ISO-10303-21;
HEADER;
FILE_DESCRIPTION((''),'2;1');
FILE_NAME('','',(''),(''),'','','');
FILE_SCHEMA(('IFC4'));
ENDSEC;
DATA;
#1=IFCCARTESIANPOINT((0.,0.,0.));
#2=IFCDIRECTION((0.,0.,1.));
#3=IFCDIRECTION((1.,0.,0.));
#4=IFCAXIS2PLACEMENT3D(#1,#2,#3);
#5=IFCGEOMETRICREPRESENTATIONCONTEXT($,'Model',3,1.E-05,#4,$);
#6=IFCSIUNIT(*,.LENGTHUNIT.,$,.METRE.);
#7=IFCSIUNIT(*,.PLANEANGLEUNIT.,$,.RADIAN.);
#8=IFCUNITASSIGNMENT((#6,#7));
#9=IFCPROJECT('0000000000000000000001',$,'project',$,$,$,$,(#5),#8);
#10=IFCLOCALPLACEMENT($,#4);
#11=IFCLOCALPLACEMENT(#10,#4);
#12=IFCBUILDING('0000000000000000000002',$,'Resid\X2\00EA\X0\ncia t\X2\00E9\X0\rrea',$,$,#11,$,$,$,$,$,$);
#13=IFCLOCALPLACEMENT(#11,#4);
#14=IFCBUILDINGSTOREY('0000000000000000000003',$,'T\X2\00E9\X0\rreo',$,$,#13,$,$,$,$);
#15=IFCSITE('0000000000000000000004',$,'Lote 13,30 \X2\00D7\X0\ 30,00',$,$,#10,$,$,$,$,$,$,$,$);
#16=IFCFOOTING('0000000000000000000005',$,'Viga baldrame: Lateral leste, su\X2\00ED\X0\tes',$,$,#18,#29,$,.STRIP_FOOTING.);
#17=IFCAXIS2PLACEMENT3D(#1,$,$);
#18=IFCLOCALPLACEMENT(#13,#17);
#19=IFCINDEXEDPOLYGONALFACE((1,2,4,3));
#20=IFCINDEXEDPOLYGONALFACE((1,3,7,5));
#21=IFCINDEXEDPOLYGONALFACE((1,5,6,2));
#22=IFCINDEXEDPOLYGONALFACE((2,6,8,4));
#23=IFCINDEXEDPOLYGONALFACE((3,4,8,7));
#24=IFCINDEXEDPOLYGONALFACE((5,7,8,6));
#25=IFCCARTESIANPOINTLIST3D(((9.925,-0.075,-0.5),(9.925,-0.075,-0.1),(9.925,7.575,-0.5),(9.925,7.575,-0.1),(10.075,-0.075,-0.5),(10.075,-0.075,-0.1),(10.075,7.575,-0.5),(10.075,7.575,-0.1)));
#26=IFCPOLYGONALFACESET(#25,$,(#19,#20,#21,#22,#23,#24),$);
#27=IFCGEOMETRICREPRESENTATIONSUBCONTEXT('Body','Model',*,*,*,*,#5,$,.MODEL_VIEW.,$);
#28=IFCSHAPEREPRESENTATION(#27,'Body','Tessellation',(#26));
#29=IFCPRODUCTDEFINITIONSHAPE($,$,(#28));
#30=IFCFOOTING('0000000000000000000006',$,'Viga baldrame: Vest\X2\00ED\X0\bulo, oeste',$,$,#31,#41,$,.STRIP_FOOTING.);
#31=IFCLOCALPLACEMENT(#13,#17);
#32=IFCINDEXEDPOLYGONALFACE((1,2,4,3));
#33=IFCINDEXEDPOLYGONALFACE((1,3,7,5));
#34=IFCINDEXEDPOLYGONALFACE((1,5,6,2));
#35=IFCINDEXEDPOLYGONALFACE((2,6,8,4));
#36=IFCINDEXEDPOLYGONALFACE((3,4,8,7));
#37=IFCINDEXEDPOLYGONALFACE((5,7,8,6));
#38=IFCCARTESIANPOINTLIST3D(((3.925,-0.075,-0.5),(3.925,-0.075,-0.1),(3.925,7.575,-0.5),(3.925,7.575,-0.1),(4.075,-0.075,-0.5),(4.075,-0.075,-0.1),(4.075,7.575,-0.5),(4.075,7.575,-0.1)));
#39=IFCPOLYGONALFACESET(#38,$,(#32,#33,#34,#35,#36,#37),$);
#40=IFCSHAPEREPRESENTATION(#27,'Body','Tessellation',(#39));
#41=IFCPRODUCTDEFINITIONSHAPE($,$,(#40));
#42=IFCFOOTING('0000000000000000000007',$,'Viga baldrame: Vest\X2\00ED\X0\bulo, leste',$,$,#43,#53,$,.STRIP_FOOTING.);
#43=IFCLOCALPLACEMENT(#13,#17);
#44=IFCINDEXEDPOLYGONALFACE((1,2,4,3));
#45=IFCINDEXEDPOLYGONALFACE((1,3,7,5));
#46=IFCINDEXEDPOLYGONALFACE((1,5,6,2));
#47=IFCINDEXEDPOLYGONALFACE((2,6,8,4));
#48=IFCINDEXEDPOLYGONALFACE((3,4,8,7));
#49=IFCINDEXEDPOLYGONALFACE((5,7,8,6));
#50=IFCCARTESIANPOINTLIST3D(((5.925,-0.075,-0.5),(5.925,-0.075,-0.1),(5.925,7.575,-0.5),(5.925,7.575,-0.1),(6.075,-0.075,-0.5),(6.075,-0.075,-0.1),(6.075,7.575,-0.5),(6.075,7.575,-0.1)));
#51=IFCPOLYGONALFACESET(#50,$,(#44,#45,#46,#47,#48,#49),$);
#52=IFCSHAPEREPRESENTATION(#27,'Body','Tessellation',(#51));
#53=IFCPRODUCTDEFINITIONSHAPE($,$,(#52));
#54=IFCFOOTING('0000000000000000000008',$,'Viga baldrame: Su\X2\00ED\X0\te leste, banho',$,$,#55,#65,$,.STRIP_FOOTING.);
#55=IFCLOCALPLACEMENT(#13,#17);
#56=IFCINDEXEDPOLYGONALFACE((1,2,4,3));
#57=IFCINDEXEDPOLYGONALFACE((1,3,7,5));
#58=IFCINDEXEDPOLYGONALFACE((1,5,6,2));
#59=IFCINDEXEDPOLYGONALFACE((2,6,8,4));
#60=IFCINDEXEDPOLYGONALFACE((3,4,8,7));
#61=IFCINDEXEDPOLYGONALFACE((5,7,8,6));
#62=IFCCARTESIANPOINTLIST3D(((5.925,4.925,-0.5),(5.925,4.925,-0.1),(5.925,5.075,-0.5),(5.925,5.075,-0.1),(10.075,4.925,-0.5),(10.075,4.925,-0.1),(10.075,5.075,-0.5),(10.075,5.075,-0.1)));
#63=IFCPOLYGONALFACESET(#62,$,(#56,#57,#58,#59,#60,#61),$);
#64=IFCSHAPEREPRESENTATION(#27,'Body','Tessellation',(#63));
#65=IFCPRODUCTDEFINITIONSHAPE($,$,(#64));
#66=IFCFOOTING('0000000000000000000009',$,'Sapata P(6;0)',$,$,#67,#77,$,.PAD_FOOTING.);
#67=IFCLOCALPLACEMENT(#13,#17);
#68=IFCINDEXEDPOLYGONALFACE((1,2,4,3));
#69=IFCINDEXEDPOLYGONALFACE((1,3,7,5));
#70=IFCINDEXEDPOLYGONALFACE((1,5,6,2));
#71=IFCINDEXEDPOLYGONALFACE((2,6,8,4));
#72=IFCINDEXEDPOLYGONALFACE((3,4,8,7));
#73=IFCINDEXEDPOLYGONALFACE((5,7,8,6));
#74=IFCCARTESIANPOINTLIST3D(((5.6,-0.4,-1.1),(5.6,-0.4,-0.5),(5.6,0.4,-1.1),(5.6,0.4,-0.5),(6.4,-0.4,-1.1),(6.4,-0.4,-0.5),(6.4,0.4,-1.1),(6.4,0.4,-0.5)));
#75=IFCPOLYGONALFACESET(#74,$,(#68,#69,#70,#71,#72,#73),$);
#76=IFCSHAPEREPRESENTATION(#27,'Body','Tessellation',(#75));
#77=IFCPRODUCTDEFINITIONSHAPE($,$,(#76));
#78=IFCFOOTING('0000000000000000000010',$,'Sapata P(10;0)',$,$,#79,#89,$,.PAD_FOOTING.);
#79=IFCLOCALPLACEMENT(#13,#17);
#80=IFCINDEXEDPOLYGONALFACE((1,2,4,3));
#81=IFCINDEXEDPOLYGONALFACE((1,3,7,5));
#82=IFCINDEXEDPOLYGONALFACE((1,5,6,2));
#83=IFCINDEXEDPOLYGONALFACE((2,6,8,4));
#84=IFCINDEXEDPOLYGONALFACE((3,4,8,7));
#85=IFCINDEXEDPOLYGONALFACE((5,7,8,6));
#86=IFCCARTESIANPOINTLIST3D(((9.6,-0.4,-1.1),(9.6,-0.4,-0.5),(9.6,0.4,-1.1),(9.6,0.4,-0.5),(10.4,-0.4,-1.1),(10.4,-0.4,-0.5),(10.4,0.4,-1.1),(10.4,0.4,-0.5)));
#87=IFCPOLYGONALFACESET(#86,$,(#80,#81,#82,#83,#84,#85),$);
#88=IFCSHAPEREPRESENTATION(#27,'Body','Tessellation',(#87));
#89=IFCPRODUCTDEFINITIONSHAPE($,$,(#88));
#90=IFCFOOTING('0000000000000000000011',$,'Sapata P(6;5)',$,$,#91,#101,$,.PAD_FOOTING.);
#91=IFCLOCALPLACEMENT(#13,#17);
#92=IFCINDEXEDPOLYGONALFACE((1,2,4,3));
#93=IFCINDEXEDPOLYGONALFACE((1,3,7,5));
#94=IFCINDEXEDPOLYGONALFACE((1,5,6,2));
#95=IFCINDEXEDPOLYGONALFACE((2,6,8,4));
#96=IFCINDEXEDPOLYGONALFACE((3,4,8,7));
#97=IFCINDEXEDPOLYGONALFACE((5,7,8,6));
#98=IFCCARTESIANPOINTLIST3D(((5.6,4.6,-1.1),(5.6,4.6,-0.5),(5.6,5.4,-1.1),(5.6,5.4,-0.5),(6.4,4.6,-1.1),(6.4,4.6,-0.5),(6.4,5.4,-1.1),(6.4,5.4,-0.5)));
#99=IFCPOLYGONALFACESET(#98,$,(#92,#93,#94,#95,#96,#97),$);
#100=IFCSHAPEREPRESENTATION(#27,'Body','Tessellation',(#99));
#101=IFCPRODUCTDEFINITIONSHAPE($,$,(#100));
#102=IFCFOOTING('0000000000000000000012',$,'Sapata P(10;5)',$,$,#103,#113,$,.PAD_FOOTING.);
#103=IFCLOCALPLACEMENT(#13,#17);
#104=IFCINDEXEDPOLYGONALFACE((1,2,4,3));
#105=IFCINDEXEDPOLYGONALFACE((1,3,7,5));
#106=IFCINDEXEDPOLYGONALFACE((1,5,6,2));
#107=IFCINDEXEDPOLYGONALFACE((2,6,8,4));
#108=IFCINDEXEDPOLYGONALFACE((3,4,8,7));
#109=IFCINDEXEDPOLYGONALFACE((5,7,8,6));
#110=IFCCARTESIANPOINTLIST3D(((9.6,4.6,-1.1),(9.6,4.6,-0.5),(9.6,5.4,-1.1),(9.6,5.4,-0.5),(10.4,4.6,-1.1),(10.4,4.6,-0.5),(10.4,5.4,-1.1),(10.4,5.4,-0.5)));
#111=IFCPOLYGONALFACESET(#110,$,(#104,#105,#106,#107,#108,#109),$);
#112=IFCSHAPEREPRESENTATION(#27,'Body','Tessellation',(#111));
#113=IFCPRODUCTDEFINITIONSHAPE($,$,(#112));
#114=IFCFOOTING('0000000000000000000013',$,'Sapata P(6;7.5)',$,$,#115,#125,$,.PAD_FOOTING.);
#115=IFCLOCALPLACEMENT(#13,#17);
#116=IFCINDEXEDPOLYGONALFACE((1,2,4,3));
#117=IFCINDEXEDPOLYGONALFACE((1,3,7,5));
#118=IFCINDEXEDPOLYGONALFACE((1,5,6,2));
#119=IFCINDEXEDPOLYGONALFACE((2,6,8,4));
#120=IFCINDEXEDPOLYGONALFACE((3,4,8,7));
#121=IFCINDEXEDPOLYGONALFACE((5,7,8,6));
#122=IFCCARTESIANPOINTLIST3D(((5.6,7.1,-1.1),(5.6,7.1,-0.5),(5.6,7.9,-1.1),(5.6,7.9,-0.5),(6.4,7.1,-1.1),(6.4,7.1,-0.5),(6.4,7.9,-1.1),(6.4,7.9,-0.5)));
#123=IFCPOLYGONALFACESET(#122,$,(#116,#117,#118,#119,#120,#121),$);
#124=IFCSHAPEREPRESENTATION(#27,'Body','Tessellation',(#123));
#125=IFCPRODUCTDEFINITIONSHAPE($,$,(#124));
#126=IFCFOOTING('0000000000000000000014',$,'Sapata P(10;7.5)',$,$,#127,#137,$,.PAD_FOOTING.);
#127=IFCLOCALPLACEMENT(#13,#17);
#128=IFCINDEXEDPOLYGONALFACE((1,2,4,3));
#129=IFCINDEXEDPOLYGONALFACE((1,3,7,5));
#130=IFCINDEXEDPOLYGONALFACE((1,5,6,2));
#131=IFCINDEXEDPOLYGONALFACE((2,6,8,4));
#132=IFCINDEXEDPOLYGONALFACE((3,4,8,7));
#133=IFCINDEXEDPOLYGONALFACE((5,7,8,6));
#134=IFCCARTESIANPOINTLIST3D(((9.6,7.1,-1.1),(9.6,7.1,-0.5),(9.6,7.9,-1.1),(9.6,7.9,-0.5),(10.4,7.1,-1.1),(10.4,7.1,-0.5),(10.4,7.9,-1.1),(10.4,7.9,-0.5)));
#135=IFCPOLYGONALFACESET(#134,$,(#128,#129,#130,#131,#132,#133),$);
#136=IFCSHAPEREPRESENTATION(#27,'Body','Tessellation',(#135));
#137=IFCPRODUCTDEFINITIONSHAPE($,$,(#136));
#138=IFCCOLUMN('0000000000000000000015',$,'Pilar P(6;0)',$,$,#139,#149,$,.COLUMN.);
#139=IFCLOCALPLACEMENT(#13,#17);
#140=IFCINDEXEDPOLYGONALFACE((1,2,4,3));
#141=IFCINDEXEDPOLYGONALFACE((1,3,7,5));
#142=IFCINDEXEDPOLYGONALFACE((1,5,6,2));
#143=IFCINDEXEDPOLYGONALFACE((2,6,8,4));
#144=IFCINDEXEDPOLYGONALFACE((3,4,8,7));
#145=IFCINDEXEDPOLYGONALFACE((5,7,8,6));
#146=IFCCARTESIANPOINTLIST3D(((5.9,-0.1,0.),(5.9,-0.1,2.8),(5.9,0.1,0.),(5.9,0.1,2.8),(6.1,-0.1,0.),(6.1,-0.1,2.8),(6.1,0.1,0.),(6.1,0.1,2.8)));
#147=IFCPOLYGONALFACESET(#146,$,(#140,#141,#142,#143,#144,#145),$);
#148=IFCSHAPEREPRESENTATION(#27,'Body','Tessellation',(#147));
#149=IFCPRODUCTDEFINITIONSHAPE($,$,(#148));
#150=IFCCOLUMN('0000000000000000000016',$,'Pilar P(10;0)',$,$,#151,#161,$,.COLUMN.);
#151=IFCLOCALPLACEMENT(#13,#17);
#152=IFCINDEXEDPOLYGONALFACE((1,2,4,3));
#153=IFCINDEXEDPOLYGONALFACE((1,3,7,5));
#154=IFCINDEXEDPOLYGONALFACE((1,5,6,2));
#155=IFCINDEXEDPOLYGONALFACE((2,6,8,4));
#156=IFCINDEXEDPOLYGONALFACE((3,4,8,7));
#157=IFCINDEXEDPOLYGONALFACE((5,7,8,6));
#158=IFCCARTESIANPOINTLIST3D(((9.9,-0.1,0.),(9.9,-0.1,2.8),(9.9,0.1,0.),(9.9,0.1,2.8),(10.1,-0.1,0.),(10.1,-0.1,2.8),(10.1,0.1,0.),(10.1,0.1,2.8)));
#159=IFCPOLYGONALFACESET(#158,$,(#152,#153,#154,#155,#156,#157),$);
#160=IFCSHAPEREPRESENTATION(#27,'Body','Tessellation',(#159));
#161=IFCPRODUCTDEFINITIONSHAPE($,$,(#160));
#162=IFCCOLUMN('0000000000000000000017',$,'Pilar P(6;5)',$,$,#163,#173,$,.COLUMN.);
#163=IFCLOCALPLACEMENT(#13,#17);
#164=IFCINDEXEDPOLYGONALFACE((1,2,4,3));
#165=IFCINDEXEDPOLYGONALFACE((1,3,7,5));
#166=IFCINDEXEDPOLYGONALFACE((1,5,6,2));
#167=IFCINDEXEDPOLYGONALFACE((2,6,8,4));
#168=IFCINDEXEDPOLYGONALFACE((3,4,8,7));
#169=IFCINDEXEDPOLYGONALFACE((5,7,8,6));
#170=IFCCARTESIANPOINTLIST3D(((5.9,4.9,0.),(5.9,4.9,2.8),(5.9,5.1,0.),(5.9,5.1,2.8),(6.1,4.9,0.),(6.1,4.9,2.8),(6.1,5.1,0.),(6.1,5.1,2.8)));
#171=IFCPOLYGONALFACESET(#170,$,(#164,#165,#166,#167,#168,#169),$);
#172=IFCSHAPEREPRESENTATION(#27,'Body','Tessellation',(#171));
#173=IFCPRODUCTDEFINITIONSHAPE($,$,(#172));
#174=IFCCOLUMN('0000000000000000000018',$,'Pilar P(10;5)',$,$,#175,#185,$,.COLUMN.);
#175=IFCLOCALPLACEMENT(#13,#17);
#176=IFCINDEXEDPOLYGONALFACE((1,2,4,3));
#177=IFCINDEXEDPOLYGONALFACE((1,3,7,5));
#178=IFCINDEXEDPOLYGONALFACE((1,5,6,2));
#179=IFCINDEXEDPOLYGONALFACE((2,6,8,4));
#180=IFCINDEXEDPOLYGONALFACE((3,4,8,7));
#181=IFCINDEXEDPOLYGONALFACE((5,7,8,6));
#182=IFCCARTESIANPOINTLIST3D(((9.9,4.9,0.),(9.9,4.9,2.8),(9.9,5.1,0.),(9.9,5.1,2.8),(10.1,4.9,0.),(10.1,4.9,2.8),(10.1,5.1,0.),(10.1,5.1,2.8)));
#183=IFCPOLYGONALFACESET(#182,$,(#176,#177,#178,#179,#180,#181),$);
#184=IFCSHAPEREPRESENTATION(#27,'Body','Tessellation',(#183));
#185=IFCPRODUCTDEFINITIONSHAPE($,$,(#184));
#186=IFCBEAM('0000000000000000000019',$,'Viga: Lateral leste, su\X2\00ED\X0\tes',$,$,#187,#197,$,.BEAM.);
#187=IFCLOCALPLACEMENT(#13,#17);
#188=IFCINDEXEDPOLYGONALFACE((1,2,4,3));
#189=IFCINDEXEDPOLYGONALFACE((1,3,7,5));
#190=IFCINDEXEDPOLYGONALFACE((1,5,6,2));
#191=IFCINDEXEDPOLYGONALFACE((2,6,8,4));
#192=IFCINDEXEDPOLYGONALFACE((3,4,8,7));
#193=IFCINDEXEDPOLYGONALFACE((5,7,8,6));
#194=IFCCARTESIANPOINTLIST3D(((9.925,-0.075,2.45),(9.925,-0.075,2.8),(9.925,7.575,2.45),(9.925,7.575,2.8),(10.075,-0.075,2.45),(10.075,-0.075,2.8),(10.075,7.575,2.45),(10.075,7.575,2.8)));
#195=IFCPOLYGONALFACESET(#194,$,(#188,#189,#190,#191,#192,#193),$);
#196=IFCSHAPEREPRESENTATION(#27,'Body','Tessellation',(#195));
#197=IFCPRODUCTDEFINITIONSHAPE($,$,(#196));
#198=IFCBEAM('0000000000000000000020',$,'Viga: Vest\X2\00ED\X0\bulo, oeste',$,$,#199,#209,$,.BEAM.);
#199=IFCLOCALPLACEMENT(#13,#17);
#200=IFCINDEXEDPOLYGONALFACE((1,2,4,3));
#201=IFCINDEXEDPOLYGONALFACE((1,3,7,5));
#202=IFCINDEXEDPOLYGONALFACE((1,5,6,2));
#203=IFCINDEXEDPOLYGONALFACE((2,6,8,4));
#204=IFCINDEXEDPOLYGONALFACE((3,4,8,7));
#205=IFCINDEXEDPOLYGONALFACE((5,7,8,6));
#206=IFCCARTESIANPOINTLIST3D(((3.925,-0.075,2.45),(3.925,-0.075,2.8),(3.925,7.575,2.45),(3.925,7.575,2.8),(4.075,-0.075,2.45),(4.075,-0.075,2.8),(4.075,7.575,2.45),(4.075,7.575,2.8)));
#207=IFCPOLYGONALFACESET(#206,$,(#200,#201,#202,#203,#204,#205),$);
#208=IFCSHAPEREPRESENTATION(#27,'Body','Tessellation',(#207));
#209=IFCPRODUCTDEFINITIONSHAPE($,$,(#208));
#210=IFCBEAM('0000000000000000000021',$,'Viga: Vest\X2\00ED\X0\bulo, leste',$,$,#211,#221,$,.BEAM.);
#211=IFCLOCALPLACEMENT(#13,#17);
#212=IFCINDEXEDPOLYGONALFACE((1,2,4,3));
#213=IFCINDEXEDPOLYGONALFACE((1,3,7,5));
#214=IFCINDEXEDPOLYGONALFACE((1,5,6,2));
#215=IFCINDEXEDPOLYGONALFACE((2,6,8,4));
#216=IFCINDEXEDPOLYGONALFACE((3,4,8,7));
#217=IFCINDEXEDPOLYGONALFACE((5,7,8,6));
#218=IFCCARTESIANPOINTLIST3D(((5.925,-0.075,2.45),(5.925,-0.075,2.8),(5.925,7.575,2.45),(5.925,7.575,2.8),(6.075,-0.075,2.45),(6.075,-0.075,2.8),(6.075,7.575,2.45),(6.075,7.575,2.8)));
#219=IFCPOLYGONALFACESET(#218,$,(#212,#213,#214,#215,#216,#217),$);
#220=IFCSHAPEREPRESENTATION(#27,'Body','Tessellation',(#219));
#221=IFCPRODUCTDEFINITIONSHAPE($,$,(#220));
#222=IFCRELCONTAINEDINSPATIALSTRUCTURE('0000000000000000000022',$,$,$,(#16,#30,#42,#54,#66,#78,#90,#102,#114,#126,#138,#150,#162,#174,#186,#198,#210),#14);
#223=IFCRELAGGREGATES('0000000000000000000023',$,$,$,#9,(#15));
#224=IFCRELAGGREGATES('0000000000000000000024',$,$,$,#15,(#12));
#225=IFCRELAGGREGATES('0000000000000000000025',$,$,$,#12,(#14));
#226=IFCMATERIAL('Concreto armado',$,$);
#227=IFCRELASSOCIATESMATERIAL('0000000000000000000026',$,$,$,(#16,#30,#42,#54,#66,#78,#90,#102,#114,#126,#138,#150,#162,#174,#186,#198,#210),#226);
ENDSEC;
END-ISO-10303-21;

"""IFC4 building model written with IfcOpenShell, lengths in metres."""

from ifc_helpers import new_model, si_unit, frame, origin_with_axes, place, context, subcontext, project, spatial, line, indexed_curve, outline, extrude, material, element, save


model = new_model("IFC4")

# Units and contexts
model_context = context("Model", 3, precision=1e-05, world=origin_with_axes())
body_context = subcontext(model_context, "Body", "Model", "MODEL_VIEW")
ifc_project = project(units=[si_unit("LENGTHUNIT", "METRE"), si_unit("PLANEANGLEUNIT", "RADIAN")], contexts=[model_context])

# Site, building, storey
site_placement = place(None, origin_with_axes())
site = spatial("IfcSite", under=ifc_project, at=site_placement, Name="Lote 13,30 × 30,00")
building_placement = place(site_placement, origin_with_axes())
building = spatial("IfcBuilding", under=site, at=building_placement, Name="Residência térrea")
storey_placement = place(building_placement, origin_with_axes())
storey = spatial("IfcBuildingStorey", under=building, at=storey_placement, Name="Térreo")

# Footings
ifc_material_1 = material(Name="Concreto armado")
footing_1_placement = place(storey_placement, frame((9.925, -0.075, -0.5), z_axis=(0.0, 0.0, 1.0), x_axis=(1.0, 0.0, 0.0)))
element("IfcFooting", 1, at=footing_1_placement, inside=storey, material=ifc_material_1, Name="Viga baldrame: Lateral leste, suítes", PredefinedType="STRIP_FOOTING", context=body_context, shape_type="SweptSolid", body=[
    extrude(outline(indexed_curve([(0.0, 0.0), (0.15, 0.0), (0.15, 7.65), (0.0, 7.65)], segments=[line(1, 2, 3, 4, 1)])), origin_with_axes(), (0.0, 0.0, 1.0), 0.4),
])
for number, where, z_axis, x_axis, name in (
    (2, (3.925, -0.075, -0.5), (0.0, 0.0, 1.0), (1.0, 0.0, 0.0), "Viga baldrame: Vestíbulo, oeste"),
    (3, (5.925, -0.075, -0.5), (0.0, 0.0, 1.0), (1.0, 0.0, 0.0), "Viga baldrame: Vestíbulo, leste"),
):
    element("IfcFooting", number, at=place(storey_placement, frame(where, z_axis=z_axis, x_axis=x_axis)), inside=storey, material=ifc_material_1, Name=name, PredefinedType="STRIP_FOOTING", context=body_context, shape_type="SweptSolid", body=[
        extrude(outline(indexed_curve([(0.0, 0.0), (0.15, 0.0), (0.15, 7.65), (0.0, 7.65)], segments=[line(1, 2, 3, 4, 1)])), origin_with_axes(), (0.0, 0.0, 1.0), 0.4),
    ])
footing_2_placement = place(storey_placement, frame((5.925, 4.925, -0.5), z_axis=(0.0, 0.0, 1.0), x_axis=(1.0, 0.0, 0.0)))
element("IfcFooting", 4, at=footing_2_placement, inside=storey, material=ifc_material_1, Name="Viga baldrame: Suíte leste, banho", PredefinedType="STRIP_FOOTING", context=body_context, shape_type="SweptSolid", body=[
    extrude(outline(indexed_curve([(0.0, 0.0), (4.15, 0.0), (4.15, 0.15), (0.0, 0.15)], segments=[line(1, 2, 3, 4, 1)])), origin_with_axes(), (0.0, 0.0, 1.0), 0.4),
])
for number, where, z_axis, x_axis, name in (
    (5, (5.6, -0.4, -1.1), (0.0, 0.0, 1.0), (1.0, 0.0, 0.0), "Sapata P(6;0)"),
    (6, (9.6, -0.4, -1.1), (0.0, 0.0, 1.0), (1.0, 0.0, 0.0), "Sapata P(10;0)"),
):
    element("IfcFooting", number, at=place(storey_placement, frame(where, z_axis=z_axis, x_axis=x_axis)), inside=storey, material=ifc_material_1, Name=name, PredefinedType="PAD_FOOTING", context=body_context, shape_type="SweptSolid", body=[
        extrude(outline(indexed_curve([(0.0, 0.0), (0.8, 0.0), (0.8, 0.8), (0.0, 0.8)], segments=[line(1, 2, 3, 4, 1)])), origin_with_axes(), (0.0, 0.0, 1.0), 0.6),
    ])
for number, where, z_axis, x_axis, name in (
    (7, (5.6, 4.6, -1.1), (0.0, 0.0, 1.0), (1.0, 0.0, 0.0), "Sapata P(6;5)"),
    (8, (9.6, 4.6, -1.1), (0.0, 0.0, 1.0), (1.0, 0.0, 0.0), "Sapata P(10;5)"),
    (9, (5.6, 7.1, -1.1), (0.0, 0.0, 1.0), (1.0, 0.0, 0.0), "Sapata P(6;7.5)"),
    (10, (9.6, 7.1, -1.1), (0.0, 0.0, 1.0), (1.0, 0.0, 0.0), "Sapata P(10;7.5)"),
):
    element("IfcFooting", number, at=place(storey_placement, frame(where, z_axis=z_axis, x_axis=x_axis)), inside=storey, material=ifc_material_1, Name=name, PredefinedType="PAD_FOOTING", context=body_context, shape_type="SweptSolid", body=[
        extrude(outline(indexed_curve([(0.0, 0.0), (0.8, 0.0), (0.8, 0.8), (0.0, 0.8)], segments=[line(1, 2, 3, 4, 1)])), origin_with_axes(), (0.0, 0.0, 1.0), 0.6),
    ])

# Columns
for number, where, z_axis, x_axis, name in (
    (11, (5.9, -0.1, 0.0), (0.0, 0.0, 1.0), (1.0, 0.0, 0.0), "Pilar P(6;0)"),
    (12, (9.9, -0.1, 0.0), (0.0, 0.0, 1.0), (1.0, 0.0, 0.0), "Pilar P(10;0)"),
):
    element("IfcColumn", number, at=place(storey_placement, frame(where, z_axis=z_axis, x_axis=x_axis)), inside=storey, material=ifc_material_1, Name=name, PredefinedType="COLUMN", context=body_context, shape_type="SweptSolid", body=[
        extrude(outline(indexed_curve([(0.0, 0.0), (0.2, 0.0), (0.2, 0.2), (0.0, 0.2)], segments=[line(1, 2, 3, 4, 1)])), origin_with_axes(), (0.0, 0.0, 1.0), 2.8),
    ])
for number, where, z_axis, x_axis, name in (
    (13, (5.9, 4.9, 0.0), (0.0, 0.0, 1.0), (1.0, 0.0, 0.0), "Pilar P(6;5)"),
    (14, (9.9, 4.9, 0.0), (0.0, 0.0, 1.0), (1.0, 0.0, 0.0), "Pilar P(10;5)"),
):
    element("IfcColumn", number, at=place(storey_placement, frame(where, z_axis=z_axis, x_axis=x_axis)), inside=storey, material=ifc_material_1, Name=name, PredefinedType="COLUMN", context=body_context, shape_type="SweptSolid", body=[
        extrude(outline(indexed_curve([(0.0, 0.0), (0.2, 0.0), (0.2, 0.2), (0.0, 0.2)], segments=[line(1, 2, 3, 4, 1)])), origin_with_axes(), (0.0, 0.0, 1.0), 2.8),
    ])

# Beams
beam_1_placement = place(storey_placement, frame((9.925, -0.075, 2.45), z_axis=(0.0, 0.0, 1.0), x_axis=(1.0, 0.0, 0.0)))
element("IfcBeam", 15, at=beam_1_placement, inside=storey, material=ifc_material_1, Name="Viga: Lateral leste, suítes", PredefinedType="BEAM", context=body_context, shape_type="SweptSolid", body=[
    extrude(outline(indexed_curve([(0.0, 0.0), (0.15, 0.0), (0.15, 7.65), (0.0, 7.65)], segments=[line(1, 2, 3, 4, 1)])), origin_with_axes(), (0.0, 0.0, 1.0), 0.35),
])
for number, where, z_axis, x_axis, name in (
    (16, (3.925, -0.075, 2.45), (0.0, 0.0, 1.0), (1.0, 0.0, 0.0), "Viga: Vestíbulo, oeste"),
    (17, (5.925, -0.075, 2.45), (0.0, 0.0, 1.0), (1.0, 0.0, 0.0), "Viga: Vestíbulo, leste"),
):
    element("IfcBeam", number, at=place(storey_placement, frame(where, z_axis=z_axis, x_axis=x_axis)), inside=storey, material=ifc_material_1, Name=name, PredefinedType="BEAM", context=body_context, shape_type="SweptSolid", body=[
        extrude(outline(indexed_curve([(0.0, 0.0), (0.15, 0.0), (0.15, 7.65), (0.0, 7.65)], segments=[line(1, 2, 3, 4, 1)])), origin_with_axes(), (0.0, 0.0, 1.0), 0.35),
    ])

save(model, "model.ifc")
